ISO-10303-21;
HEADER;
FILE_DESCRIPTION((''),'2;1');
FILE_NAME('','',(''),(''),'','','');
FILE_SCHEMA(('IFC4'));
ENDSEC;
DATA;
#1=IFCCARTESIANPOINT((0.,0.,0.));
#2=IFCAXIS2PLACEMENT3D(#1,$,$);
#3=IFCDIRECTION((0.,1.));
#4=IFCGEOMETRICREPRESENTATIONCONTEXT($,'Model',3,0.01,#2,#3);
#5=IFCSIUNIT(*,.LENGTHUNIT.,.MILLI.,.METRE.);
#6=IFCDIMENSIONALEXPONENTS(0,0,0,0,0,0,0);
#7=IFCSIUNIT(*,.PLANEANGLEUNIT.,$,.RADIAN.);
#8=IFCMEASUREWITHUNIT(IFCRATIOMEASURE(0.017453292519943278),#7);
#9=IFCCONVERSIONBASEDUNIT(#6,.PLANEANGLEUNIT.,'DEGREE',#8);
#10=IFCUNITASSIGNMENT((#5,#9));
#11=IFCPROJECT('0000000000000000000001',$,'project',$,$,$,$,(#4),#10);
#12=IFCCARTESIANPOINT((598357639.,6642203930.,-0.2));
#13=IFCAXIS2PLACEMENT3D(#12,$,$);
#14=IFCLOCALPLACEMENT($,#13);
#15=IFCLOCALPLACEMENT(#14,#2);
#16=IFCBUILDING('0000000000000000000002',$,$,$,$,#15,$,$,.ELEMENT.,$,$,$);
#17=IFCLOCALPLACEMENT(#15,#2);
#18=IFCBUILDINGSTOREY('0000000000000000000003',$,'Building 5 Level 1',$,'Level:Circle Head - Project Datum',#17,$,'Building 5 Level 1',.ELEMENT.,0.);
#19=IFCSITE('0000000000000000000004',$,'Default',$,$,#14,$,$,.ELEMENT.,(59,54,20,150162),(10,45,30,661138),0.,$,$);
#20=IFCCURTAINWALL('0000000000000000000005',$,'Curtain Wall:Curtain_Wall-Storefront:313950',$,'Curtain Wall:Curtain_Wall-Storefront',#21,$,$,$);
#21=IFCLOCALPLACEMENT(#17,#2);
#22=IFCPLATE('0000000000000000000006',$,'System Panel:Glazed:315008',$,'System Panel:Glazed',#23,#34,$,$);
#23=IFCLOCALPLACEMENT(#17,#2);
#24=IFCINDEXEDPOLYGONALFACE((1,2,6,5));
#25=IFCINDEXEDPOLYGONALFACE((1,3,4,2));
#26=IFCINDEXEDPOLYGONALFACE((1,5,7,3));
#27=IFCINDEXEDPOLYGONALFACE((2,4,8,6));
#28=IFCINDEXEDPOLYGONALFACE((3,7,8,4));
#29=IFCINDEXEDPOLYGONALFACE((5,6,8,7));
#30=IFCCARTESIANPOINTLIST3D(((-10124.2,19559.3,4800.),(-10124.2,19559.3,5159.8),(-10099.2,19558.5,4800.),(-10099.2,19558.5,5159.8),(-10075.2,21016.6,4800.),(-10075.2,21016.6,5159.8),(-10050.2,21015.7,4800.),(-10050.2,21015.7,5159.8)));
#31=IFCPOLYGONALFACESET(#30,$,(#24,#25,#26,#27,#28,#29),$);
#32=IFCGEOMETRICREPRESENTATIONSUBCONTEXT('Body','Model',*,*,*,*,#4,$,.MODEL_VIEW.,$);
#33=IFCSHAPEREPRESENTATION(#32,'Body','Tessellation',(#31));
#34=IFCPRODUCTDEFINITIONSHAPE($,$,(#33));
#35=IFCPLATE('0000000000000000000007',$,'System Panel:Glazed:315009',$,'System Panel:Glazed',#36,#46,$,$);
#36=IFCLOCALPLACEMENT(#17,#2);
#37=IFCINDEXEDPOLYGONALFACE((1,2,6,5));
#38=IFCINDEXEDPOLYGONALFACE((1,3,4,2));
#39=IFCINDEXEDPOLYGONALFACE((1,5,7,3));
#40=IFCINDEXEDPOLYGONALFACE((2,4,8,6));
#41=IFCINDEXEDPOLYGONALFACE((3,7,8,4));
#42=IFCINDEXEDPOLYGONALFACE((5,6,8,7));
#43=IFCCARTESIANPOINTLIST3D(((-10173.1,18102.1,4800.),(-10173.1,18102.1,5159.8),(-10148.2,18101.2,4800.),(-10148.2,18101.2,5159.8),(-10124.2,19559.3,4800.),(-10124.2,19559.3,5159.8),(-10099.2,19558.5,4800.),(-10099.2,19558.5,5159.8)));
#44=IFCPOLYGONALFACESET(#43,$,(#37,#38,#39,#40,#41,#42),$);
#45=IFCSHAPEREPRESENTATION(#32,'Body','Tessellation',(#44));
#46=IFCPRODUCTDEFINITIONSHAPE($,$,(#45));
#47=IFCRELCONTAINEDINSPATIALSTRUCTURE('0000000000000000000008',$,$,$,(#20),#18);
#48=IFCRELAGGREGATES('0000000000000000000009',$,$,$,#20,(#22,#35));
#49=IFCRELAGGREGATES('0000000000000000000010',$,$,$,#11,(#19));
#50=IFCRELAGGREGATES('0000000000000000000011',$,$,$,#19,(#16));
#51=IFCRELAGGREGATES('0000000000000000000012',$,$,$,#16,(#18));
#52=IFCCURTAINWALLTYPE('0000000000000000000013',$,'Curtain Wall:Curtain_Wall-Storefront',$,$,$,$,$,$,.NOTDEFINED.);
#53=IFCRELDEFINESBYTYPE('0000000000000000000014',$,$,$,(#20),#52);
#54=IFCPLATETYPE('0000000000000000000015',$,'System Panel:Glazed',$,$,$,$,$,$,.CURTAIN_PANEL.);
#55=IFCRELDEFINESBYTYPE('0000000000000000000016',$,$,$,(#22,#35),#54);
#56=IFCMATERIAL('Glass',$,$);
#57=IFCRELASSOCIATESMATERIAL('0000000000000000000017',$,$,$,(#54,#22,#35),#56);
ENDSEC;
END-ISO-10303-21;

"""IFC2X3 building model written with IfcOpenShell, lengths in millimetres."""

from ifc_helpers import new_model, entity, si_unit, converted_unit, direction, frame, frame_2d, origin, place, context, subcontext, project, spatial, rectangle, extrude, source, transform, mapped, material, type_object, type_shapes, element, aggregate, save


model = new_model("IFC2X3")

# Units and contexts
model_context = context("Model", 3, precision=0.01, world=origin(), true_north=direction((0.0, 1.0)))
body_context = subcontext(model_context, "Body", "Model", "MODEL_VIEW")
ifc_project = project(units=[si_unit("LENGTHUNIT", "METRE", prefix="MILLI"), converted_unit("PLANEANGLEUNIT", "DEGREE", entity("IfcRatioMeasure", 0.017453292519943278), si_unit("PLANEANGLEUNIT", "RADIAN"), dimensions=[0, 0, 0, 0, 0, 0, 0])], contexts=[model_context])

# Site, building, storey
site_placement = place(None, frame((598357639.0, 6642203930.0, -0.2)))
site = spatial("IfcSite", under=ifc_project, at=site_placement, Name="Default", CompositionType="ELEMENT", RefLatitude=(59, 54, 20, 150162), RefLongitude=(10, 45, 30, 661138), RefElevation=0.0)
building_placement = place(site_placement, origin())
building = spatial("IfcBuilding", under=site, at=building_placement, CompositionType="ELEMENT")
storey_placement = place(building_placement, origin())
storey = spatial("IfcBuildingStorey", under=building, at=storey_placement, Name="Building 5 Level 1", ObjectType="Level:Circle Head - Project Datum", LongName="Building 5 Level 1", CompositionType="ELEMENT", Elevation=0.0)

# Curtain wall, plates
curtain_wall_type = type_object("IfcCurtainWallType", Name="Curtain Wall:Curtain_Wall-Storefront", PredefinedType="NOTDEFINED")
ifc_material = material(Name="Glass")
curtain_wall_1_placement = place(storey_placement, origin())
curtain_wall_1 = element("IfcCurtainWall", 1, at=curtain_wall_1_placement, inside=storey, type_object=curtain_wall_type, Name="Curtain Wall:Curtain_Wall-Storefront:313950", ObjectType="Curtain Wall:Curtain_Wall-Storefront")
plate_type_1 = type_object("IfcPlateType", Name="System Panel:Glazed", PredefinedType="CURTAIN_PANEL", material=ifc_material)
shared_shape_1 = source(origin(), body_context, "Body", "SweptSolid", [
    extrude(rectangle(XDim=25.0, YDim=1458.1, at=frame_2d((0.0, 0.0), x_axis=(1.0, 0.0))), frame((0.0, -37.0, 0.0), z_axis=(0.0, 0.0, 1.0), x_axis=(0.0, 1.0, 0.0)), (0.0, 0.0, 1.0), 359.8),
])
type_shapes(plate_type_1, [shared_shape_1])
plate_1_placement = place(curtain_wall_1_placement, frame((-10050.2, 20286.3, 4800.0), z_axis=(0.0, 0.0, 1.0), x_axis=(-0.033601, -0.999435, 0.0)))
plate_1 = element("IfcPlate", 2, at=plate_1_placement, type_object=plate_type_1, material=ifc_material, Name="System Panel:Glazed:315008", ObjectType="System Panel:Glazed", context=body_context, shape_type="MappedRepresentation", body=[
    mapped(shared_shape_1, transform((0.0, 0.0, 0.0), scale=1.0)),
])
plate_2_placement = place(curtain_wall_1_placement, frame((-10099.2, 18829.0, 4800.0), z_axis=(0.0, 0.0, 1.0), x_axis=(-0.033601, -0.999435, 0.0)))
plate_2 = element("IfcPlate", 3, at=plate_2_placement, type_object=plate_type_1, material=ifc_material, Name="System Panel:Glazed:315009", ObjectType="System Panel:Glazed", context=body_context, shape_type="MappedRepresentation", body=[
    mapped(shared_shape_1, transform((0.0, 0.0, 0.0), scale=1.0)),
])
aggregate(curtain_wall_1, [plate_1, plate_2])

save(model, "model.ifc")
